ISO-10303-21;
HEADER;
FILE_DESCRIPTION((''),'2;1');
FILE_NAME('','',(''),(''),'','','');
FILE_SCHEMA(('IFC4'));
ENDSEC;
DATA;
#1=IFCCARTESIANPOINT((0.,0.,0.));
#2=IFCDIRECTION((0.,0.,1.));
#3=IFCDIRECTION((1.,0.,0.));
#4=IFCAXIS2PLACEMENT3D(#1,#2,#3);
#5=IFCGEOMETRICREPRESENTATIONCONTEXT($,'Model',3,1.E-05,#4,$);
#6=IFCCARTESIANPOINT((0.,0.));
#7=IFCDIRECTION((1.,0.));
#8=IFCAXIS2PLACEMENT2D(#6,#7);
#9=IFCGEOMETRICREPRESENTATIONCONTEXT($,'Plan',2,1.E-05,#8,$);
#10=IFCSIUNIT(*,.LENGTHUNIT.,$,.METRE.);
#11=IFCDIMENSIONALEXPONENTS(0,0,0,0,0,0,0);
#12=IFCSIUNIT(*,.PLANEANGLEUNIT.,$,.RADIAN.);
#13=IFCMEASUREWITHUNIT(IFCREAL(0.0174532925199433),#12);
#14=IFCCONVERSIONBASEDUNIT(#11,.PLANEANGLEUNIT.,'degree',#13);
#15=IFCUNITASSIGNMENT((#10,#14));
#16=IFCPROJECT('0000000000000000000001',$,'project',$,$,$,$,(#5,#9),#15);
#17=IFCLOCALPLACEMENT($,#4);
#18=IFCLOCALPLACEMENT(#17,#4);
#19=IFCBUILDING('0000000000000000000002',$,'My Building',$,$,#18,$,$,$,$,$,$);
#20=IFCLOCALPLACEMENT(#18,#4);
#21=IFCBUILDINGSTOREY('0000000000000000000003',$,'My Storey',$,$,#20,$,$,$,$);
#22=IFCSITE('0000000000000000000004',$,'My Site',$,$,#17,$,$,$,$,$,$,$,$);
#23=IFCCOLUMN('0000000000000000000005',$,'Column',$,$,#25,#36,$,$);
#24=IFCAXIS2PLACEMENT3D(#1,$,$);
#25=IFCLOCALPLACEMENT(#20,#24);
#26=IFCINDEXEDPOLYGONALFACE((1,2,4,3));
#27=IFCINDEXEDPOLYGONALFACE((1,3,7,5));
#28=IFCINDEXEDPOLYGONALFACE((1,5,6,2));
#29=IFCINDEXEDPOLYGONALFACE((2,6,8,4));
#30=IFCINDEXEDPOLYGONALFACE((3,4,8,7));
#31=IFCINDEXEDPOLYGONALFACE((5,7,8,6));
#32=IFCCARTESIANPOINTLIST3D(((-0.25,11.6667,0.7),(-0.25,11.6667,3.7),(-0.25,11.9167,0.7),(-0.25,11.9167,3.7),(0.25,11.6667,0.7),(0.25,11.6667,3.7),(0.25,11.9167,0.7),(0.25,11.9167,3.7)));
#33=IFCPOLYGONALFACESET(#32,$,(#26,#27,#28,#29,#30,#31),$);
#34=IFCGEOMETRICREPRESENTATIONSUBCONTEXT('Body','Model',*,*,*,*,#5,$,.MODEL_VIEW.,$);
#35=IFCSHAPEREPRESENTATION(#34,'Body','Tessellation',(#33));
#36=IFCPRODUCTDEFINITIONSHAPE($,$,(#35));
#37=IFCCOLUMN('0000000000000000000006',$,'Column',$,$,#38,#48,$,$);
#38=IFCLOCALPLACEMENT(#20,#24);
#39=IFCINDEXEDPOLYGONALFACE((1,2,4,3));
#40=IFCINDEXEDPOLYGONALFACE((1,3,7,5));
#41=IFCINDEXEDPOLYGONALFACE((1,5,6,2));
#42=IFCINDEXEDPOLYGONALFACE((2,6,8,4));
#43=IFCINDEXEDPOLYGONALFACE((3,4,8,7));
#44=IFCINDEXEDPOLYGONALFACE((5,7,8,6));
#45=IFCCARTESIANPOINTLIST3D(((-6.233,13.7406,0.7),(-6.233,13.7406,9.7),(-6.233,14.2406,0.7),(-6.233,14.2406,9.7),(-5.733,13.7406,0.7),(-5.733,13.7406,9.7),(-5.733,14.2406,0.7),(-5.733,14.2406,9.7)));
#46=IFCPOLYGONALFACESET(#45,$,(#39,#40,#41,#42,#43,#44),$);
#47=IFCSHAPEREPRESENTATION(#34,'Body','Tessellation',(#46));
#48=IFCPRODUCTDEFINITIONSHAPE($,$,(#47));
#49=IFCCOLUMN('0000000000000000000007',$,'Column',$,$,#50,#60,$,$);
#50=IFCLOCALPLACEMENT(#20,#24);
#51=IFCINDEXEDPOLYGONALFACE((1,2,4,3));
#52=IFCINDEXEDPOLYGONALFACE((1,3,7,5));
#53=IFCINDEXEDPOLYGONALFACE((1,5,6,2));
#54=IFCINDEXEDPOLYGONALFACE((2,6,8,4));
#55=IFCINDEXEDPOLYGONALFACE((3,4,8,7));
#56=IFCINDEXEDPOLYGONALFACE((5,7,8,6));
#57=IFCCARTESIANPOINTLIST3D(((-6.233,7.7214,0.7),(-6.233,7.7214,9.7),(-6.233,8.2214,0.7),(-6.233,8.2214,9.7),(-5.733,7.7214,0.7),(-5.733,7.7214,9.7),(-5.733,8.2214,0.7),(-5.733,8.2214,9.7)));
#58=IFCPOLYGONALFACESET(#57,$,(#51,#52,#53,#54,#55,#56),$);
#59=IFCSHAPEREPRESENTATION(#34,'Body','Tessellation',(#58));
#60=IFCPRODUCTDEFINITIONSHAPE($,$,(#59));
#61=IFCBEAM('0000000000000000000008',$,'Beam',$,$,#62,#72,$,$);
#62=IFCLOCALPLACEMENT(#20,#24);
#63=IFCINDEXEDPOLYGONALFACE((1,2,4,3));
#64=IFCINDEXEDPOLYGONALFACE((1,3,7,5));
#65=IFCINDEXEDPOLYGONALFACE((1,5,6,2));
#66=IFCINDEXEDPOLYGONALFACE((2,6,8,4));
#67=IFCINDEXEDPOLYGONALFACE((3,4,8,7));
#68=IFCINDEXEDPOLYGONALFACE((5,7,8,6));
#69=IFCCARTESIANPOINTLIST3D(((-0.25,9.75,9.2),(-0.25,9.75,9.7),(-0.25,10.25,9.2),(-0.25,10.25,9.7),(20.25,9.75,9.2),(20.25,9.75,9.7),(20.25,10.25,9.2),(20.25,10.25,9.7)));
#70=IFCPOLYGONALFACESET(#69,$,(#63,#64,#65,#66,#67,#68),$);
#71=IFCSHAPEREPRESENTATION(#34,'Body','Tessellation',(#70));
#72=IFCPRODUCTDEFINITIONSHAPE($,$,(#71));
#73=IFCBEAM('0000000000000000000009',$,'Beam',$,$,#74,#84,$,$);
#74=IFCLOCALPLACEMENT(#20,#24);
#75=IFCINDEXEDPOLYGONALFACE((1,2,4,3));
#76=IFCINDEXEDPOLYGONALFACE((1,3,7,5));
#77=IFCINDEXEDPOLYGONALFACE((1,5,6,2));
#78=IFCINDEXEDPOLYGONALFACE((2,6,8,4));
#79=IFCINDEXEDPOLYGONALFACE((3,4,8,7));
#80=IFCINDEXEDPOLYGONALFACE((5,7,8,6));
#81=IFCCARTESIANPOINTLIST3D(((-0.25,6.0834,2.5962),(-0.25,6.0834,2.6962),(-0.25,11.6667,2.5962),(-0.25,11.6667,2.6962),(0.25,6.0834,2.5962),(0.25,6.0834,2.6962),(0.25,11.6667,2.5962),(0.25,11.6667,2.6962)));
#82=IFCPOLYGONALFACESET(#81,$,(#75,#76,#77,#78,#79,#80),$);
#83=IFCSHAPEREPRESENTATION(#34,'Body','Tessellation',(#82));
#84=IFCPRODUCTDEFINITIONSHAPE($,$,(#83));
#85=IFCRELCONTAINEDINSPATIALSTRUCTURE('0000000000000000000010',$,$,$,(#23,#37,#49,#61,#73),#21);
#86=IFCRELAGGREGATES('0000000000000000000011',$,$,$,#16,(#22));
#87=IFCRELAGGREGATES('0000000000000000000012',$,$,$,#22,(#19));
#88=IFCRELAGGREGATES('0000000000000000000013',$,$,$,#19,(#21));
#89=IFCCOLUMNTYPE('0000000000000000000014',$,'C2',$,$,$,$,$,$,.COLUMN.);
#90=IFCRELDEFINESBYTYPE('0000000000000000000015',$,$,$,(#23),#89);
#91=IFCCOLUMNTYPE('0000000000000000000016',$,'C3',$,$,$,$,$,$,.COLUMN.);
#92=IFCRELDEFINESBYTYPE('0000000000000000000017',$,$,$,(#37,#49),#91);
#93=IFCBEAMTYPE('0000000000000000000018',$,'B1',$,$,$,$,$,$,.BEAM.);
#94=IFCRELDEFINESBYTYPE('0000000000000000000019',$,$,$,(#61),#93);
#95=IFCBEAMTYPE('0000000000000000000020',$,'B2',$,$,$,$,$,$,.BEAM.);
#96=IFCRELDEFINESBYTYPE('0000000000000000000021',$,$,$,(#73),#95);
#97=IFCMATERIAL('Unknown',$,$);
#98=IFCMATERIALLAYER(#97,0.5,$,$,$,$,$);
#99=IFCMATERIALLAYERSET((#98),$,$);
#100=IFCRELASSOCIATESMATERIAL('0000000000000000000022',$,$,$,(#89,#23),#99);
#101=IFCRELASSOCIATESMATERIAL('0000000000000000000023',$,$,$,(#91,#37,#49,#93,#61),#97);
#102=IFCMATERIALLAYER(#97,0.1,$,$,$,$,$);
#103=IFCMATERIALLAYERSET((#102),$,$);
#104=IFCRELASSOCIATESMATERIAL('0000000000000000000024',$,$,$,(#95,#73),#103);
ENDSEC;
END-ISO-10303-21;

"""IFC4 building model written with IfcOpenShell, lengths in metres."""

from ifc_helpers import new_model, entity, si_unit, converted_unit, frame, origin_with_axes, origin_2d_with_axis, place, context, subcontext, project, spatial, line, indexed_curve, rectangle, outline, extrude, material, layer, layer_set, layer_usage, material_profile, profile_set, profile_usage, type_object, element, save


model = new_model("IFC4")

# Units and contexts
model_context = context("Model", 3, precision=1e-05, world=origin_with_axes())
plan_context = context("Plan", 2, precision=1e-05, world=origin_2d_with_axis())
body_context = subcontext(model_context, "Body", "Model", "MODEL_VIEW")
ifc_project = project(units=[si_unit("LENGTHUNIT", "METRE"), converted_unit("PLANEANGLEUNIT", "degree", entity("IfcReal", 0.0174532925199433), si_unit("PLANEANGLEUNIT", "RADIAN"), dimensions=[0, 0, 0, 0, 0, 0, 0])], contexts=[model_context, plan_context])

# Site, building, storey
site_placement = place(None, origin_with_axes())
site = spatial("IfcSite", under=ifc_project, at=site_placement, Name="My Site")
building_placement = place(site_placement, origin_with_axes())
building = spatial("IfcBuilding", under=site, at=building_placement, Name="My Building")
storey_placement = place(building_placement, origin_with_axes())
storey = spatial("IfcBuildingStorey", under=building, at=storey_placement, Name="My Storey")

# Columns
ifc_material = material(Name="Unknown")
ifc_layer_1 = layer(ifc_material, 0.5)
ifc_layer_set_1 = layer_set([ifc_layer_1])
ifc_layer_usage_1 = layer_usage(ifc_layer_set_1, "AXIS2", "POSITIVE", 0.0)
column_type_1 = type_object("IfcColumnType", Name="C2", PredefinedType="COLUMN", material=ifc_layer_set_1)
column_1_placement = place(storey_placement, frame((0.25, 11.6667, 0.7), z_axis=(0.0, 0.0, 1.0), x_axis=(0.000007, 1.0, 0.0)))
element("IfcColumn", 1, at=column_1_placement, inside=storey, type_object=column_type_1, material=ifc_layer_usage_1, Name="Column", context=body_context, shape_type="SweptSolid", body=[
    extrude(outline(indexed_curve([(0.0, 0.0), (0.0, 0.5), (0.25, 0.5), (0.25, 0.0)], segments=[line(1, 2, 3, 4, 1)])), origin_with_axes(), (0.0, 0.0, 1.0), 3.0),
])
ifc_material_profile_1 = material_profile(ifc_material, rectangle(XDim=0.5, YDim=0.5))
ifc_profile_set_1 = profile_set([ifc_material_profile_1])
ifc_profile_usage_1 = profile_usage(ifc_profile_set_1, cardinal=8)
column_type_2 = type_object("IfcColumnType", Name="C3", PredefinedType="COLUMN", material=ifc_profile_set_1)
column_2_placement = place(storey_placement, frame((-5.983, 14.2406, 0.7), z_axis=(0.0, 0.0, 1.0), x_axis=(1.0, 0.0, 0.0)))
element("IfcColumn", 2, at=column_2_placement, inside=storey, type_object=column_type_2, material=ifc_profile_usage_1, Name="Column", context=body_context, shape_type="SweptSolid", body=[
    extrude(rectangle(XDim=0.5, YDim=0.5), frame((0.0, -0.25, 0.0), z_axis=(0.0, 0.0, 1.0), x_axis=(1.0, 0.0, 0.0)), (0.0, 0.0, 1.0), 9.0),
])
ifc_profile_usage_2 = profile_usage(ifc_profile_set_1, cardinal=8)
column_3_placement = place(storey_placement, frame((-5.983, 8.2214, 0.7), z_axis=(0.0, 0.0, 1.0), x_axis=(1.0, 0.0, 0.0)))
element("IfcColumn", 3, at=column_3_placement, inside=storey, type_object=column_type_2, material=ifc_profile_usage_2, Name="Column", context=body_context, shape_type="SweptSolid", body=[
    extrude(rectangle(XDim=0.5, YDim=0.5), frame((0.0, -0.25, 0.0), z_axis=(0.0, 0.0, 1.0), x_axis=(1.0, 0.0, 0.0)), (0.0, 0.0, 1.0), 9.0),
])

# Beams
ifc_material_profile_2 = material_profile(ifc_material, rectangle(XDim=0.5, YDim=0.5))
ifc_profile_set_2 = profile_set([ifc_material_profile_2])
ifc_profile_usage_3 = profile_usage(ifc_profile_set_2, cardinal=8)
beam_type_1 = type_object("IfcBeamType", Name="B1", PredefinedType="BEAM", material=ifc_profile_set_2)
beam_1_placement = place(storey_placement, frame((-0.25, 10.0, 9.7), z_axis=(1.0, 0.0, 0.0), x_axis=(0.0, 1.0, 0.0)))
element("IfcBeam", 4, at=beam_1_placement, inside=storey, type_object=beam_type_1, material=ifc_profile_usage_3, Name="Beam", context=body_context, shape_type="SweptSolid", body=[
    extrude(rectangle(XDim=0.5, YDim=0.5), frame((0.0, -0.25, 0.0), z_axis=(0.0, 0.0, 1.0), x_axis=(1.0, 0.0, 0.0)), (0.0, 0.0, 1.0), 20.5),
])
ifc_layer_2 = layer(ifc_material, 0.1)
ifc_layer_set_2 = layer_set([ifc_layer_2])
ifc_layer_usage_2 = layer_usage(ifc_layer_set_2, "AXIS3", "POSITIVE", -0.1)
beam_type_2 = type_object("IfcBeamType", Name="B2", PredefinedType="BEAM", material=ifc_layer_set_2)
beam_2_placement = place(storey_placement, frame((-0.25, 6.0834, 2.6962), z_axis=(0.0, 0.0, 1.0), x_axis=(0.0, 1.0, 0.0)))
element("IfcBeam", 5, at=beam_2_placement, inside=storey, type_object=beam_type_2, material=ifc_layer_usage_2, Name="Beam", context=body_context, shape_type="SweptSolid", body=[
    extrude(outline(indexed_curve([(0.0, 0.0), (0.0, -0.5), (5.5833, -0.5), (5.5834, 0.0), (0.0, 0.0)])), frame((0.0, 0.0, -0.1), z_axis=(0.0, 0.0, 1.0), x_axis=(1.0, 0.0, 0.0)), (0.0, 0.0, 1.0), 0.1),
])

save(model, "model.ifc")
